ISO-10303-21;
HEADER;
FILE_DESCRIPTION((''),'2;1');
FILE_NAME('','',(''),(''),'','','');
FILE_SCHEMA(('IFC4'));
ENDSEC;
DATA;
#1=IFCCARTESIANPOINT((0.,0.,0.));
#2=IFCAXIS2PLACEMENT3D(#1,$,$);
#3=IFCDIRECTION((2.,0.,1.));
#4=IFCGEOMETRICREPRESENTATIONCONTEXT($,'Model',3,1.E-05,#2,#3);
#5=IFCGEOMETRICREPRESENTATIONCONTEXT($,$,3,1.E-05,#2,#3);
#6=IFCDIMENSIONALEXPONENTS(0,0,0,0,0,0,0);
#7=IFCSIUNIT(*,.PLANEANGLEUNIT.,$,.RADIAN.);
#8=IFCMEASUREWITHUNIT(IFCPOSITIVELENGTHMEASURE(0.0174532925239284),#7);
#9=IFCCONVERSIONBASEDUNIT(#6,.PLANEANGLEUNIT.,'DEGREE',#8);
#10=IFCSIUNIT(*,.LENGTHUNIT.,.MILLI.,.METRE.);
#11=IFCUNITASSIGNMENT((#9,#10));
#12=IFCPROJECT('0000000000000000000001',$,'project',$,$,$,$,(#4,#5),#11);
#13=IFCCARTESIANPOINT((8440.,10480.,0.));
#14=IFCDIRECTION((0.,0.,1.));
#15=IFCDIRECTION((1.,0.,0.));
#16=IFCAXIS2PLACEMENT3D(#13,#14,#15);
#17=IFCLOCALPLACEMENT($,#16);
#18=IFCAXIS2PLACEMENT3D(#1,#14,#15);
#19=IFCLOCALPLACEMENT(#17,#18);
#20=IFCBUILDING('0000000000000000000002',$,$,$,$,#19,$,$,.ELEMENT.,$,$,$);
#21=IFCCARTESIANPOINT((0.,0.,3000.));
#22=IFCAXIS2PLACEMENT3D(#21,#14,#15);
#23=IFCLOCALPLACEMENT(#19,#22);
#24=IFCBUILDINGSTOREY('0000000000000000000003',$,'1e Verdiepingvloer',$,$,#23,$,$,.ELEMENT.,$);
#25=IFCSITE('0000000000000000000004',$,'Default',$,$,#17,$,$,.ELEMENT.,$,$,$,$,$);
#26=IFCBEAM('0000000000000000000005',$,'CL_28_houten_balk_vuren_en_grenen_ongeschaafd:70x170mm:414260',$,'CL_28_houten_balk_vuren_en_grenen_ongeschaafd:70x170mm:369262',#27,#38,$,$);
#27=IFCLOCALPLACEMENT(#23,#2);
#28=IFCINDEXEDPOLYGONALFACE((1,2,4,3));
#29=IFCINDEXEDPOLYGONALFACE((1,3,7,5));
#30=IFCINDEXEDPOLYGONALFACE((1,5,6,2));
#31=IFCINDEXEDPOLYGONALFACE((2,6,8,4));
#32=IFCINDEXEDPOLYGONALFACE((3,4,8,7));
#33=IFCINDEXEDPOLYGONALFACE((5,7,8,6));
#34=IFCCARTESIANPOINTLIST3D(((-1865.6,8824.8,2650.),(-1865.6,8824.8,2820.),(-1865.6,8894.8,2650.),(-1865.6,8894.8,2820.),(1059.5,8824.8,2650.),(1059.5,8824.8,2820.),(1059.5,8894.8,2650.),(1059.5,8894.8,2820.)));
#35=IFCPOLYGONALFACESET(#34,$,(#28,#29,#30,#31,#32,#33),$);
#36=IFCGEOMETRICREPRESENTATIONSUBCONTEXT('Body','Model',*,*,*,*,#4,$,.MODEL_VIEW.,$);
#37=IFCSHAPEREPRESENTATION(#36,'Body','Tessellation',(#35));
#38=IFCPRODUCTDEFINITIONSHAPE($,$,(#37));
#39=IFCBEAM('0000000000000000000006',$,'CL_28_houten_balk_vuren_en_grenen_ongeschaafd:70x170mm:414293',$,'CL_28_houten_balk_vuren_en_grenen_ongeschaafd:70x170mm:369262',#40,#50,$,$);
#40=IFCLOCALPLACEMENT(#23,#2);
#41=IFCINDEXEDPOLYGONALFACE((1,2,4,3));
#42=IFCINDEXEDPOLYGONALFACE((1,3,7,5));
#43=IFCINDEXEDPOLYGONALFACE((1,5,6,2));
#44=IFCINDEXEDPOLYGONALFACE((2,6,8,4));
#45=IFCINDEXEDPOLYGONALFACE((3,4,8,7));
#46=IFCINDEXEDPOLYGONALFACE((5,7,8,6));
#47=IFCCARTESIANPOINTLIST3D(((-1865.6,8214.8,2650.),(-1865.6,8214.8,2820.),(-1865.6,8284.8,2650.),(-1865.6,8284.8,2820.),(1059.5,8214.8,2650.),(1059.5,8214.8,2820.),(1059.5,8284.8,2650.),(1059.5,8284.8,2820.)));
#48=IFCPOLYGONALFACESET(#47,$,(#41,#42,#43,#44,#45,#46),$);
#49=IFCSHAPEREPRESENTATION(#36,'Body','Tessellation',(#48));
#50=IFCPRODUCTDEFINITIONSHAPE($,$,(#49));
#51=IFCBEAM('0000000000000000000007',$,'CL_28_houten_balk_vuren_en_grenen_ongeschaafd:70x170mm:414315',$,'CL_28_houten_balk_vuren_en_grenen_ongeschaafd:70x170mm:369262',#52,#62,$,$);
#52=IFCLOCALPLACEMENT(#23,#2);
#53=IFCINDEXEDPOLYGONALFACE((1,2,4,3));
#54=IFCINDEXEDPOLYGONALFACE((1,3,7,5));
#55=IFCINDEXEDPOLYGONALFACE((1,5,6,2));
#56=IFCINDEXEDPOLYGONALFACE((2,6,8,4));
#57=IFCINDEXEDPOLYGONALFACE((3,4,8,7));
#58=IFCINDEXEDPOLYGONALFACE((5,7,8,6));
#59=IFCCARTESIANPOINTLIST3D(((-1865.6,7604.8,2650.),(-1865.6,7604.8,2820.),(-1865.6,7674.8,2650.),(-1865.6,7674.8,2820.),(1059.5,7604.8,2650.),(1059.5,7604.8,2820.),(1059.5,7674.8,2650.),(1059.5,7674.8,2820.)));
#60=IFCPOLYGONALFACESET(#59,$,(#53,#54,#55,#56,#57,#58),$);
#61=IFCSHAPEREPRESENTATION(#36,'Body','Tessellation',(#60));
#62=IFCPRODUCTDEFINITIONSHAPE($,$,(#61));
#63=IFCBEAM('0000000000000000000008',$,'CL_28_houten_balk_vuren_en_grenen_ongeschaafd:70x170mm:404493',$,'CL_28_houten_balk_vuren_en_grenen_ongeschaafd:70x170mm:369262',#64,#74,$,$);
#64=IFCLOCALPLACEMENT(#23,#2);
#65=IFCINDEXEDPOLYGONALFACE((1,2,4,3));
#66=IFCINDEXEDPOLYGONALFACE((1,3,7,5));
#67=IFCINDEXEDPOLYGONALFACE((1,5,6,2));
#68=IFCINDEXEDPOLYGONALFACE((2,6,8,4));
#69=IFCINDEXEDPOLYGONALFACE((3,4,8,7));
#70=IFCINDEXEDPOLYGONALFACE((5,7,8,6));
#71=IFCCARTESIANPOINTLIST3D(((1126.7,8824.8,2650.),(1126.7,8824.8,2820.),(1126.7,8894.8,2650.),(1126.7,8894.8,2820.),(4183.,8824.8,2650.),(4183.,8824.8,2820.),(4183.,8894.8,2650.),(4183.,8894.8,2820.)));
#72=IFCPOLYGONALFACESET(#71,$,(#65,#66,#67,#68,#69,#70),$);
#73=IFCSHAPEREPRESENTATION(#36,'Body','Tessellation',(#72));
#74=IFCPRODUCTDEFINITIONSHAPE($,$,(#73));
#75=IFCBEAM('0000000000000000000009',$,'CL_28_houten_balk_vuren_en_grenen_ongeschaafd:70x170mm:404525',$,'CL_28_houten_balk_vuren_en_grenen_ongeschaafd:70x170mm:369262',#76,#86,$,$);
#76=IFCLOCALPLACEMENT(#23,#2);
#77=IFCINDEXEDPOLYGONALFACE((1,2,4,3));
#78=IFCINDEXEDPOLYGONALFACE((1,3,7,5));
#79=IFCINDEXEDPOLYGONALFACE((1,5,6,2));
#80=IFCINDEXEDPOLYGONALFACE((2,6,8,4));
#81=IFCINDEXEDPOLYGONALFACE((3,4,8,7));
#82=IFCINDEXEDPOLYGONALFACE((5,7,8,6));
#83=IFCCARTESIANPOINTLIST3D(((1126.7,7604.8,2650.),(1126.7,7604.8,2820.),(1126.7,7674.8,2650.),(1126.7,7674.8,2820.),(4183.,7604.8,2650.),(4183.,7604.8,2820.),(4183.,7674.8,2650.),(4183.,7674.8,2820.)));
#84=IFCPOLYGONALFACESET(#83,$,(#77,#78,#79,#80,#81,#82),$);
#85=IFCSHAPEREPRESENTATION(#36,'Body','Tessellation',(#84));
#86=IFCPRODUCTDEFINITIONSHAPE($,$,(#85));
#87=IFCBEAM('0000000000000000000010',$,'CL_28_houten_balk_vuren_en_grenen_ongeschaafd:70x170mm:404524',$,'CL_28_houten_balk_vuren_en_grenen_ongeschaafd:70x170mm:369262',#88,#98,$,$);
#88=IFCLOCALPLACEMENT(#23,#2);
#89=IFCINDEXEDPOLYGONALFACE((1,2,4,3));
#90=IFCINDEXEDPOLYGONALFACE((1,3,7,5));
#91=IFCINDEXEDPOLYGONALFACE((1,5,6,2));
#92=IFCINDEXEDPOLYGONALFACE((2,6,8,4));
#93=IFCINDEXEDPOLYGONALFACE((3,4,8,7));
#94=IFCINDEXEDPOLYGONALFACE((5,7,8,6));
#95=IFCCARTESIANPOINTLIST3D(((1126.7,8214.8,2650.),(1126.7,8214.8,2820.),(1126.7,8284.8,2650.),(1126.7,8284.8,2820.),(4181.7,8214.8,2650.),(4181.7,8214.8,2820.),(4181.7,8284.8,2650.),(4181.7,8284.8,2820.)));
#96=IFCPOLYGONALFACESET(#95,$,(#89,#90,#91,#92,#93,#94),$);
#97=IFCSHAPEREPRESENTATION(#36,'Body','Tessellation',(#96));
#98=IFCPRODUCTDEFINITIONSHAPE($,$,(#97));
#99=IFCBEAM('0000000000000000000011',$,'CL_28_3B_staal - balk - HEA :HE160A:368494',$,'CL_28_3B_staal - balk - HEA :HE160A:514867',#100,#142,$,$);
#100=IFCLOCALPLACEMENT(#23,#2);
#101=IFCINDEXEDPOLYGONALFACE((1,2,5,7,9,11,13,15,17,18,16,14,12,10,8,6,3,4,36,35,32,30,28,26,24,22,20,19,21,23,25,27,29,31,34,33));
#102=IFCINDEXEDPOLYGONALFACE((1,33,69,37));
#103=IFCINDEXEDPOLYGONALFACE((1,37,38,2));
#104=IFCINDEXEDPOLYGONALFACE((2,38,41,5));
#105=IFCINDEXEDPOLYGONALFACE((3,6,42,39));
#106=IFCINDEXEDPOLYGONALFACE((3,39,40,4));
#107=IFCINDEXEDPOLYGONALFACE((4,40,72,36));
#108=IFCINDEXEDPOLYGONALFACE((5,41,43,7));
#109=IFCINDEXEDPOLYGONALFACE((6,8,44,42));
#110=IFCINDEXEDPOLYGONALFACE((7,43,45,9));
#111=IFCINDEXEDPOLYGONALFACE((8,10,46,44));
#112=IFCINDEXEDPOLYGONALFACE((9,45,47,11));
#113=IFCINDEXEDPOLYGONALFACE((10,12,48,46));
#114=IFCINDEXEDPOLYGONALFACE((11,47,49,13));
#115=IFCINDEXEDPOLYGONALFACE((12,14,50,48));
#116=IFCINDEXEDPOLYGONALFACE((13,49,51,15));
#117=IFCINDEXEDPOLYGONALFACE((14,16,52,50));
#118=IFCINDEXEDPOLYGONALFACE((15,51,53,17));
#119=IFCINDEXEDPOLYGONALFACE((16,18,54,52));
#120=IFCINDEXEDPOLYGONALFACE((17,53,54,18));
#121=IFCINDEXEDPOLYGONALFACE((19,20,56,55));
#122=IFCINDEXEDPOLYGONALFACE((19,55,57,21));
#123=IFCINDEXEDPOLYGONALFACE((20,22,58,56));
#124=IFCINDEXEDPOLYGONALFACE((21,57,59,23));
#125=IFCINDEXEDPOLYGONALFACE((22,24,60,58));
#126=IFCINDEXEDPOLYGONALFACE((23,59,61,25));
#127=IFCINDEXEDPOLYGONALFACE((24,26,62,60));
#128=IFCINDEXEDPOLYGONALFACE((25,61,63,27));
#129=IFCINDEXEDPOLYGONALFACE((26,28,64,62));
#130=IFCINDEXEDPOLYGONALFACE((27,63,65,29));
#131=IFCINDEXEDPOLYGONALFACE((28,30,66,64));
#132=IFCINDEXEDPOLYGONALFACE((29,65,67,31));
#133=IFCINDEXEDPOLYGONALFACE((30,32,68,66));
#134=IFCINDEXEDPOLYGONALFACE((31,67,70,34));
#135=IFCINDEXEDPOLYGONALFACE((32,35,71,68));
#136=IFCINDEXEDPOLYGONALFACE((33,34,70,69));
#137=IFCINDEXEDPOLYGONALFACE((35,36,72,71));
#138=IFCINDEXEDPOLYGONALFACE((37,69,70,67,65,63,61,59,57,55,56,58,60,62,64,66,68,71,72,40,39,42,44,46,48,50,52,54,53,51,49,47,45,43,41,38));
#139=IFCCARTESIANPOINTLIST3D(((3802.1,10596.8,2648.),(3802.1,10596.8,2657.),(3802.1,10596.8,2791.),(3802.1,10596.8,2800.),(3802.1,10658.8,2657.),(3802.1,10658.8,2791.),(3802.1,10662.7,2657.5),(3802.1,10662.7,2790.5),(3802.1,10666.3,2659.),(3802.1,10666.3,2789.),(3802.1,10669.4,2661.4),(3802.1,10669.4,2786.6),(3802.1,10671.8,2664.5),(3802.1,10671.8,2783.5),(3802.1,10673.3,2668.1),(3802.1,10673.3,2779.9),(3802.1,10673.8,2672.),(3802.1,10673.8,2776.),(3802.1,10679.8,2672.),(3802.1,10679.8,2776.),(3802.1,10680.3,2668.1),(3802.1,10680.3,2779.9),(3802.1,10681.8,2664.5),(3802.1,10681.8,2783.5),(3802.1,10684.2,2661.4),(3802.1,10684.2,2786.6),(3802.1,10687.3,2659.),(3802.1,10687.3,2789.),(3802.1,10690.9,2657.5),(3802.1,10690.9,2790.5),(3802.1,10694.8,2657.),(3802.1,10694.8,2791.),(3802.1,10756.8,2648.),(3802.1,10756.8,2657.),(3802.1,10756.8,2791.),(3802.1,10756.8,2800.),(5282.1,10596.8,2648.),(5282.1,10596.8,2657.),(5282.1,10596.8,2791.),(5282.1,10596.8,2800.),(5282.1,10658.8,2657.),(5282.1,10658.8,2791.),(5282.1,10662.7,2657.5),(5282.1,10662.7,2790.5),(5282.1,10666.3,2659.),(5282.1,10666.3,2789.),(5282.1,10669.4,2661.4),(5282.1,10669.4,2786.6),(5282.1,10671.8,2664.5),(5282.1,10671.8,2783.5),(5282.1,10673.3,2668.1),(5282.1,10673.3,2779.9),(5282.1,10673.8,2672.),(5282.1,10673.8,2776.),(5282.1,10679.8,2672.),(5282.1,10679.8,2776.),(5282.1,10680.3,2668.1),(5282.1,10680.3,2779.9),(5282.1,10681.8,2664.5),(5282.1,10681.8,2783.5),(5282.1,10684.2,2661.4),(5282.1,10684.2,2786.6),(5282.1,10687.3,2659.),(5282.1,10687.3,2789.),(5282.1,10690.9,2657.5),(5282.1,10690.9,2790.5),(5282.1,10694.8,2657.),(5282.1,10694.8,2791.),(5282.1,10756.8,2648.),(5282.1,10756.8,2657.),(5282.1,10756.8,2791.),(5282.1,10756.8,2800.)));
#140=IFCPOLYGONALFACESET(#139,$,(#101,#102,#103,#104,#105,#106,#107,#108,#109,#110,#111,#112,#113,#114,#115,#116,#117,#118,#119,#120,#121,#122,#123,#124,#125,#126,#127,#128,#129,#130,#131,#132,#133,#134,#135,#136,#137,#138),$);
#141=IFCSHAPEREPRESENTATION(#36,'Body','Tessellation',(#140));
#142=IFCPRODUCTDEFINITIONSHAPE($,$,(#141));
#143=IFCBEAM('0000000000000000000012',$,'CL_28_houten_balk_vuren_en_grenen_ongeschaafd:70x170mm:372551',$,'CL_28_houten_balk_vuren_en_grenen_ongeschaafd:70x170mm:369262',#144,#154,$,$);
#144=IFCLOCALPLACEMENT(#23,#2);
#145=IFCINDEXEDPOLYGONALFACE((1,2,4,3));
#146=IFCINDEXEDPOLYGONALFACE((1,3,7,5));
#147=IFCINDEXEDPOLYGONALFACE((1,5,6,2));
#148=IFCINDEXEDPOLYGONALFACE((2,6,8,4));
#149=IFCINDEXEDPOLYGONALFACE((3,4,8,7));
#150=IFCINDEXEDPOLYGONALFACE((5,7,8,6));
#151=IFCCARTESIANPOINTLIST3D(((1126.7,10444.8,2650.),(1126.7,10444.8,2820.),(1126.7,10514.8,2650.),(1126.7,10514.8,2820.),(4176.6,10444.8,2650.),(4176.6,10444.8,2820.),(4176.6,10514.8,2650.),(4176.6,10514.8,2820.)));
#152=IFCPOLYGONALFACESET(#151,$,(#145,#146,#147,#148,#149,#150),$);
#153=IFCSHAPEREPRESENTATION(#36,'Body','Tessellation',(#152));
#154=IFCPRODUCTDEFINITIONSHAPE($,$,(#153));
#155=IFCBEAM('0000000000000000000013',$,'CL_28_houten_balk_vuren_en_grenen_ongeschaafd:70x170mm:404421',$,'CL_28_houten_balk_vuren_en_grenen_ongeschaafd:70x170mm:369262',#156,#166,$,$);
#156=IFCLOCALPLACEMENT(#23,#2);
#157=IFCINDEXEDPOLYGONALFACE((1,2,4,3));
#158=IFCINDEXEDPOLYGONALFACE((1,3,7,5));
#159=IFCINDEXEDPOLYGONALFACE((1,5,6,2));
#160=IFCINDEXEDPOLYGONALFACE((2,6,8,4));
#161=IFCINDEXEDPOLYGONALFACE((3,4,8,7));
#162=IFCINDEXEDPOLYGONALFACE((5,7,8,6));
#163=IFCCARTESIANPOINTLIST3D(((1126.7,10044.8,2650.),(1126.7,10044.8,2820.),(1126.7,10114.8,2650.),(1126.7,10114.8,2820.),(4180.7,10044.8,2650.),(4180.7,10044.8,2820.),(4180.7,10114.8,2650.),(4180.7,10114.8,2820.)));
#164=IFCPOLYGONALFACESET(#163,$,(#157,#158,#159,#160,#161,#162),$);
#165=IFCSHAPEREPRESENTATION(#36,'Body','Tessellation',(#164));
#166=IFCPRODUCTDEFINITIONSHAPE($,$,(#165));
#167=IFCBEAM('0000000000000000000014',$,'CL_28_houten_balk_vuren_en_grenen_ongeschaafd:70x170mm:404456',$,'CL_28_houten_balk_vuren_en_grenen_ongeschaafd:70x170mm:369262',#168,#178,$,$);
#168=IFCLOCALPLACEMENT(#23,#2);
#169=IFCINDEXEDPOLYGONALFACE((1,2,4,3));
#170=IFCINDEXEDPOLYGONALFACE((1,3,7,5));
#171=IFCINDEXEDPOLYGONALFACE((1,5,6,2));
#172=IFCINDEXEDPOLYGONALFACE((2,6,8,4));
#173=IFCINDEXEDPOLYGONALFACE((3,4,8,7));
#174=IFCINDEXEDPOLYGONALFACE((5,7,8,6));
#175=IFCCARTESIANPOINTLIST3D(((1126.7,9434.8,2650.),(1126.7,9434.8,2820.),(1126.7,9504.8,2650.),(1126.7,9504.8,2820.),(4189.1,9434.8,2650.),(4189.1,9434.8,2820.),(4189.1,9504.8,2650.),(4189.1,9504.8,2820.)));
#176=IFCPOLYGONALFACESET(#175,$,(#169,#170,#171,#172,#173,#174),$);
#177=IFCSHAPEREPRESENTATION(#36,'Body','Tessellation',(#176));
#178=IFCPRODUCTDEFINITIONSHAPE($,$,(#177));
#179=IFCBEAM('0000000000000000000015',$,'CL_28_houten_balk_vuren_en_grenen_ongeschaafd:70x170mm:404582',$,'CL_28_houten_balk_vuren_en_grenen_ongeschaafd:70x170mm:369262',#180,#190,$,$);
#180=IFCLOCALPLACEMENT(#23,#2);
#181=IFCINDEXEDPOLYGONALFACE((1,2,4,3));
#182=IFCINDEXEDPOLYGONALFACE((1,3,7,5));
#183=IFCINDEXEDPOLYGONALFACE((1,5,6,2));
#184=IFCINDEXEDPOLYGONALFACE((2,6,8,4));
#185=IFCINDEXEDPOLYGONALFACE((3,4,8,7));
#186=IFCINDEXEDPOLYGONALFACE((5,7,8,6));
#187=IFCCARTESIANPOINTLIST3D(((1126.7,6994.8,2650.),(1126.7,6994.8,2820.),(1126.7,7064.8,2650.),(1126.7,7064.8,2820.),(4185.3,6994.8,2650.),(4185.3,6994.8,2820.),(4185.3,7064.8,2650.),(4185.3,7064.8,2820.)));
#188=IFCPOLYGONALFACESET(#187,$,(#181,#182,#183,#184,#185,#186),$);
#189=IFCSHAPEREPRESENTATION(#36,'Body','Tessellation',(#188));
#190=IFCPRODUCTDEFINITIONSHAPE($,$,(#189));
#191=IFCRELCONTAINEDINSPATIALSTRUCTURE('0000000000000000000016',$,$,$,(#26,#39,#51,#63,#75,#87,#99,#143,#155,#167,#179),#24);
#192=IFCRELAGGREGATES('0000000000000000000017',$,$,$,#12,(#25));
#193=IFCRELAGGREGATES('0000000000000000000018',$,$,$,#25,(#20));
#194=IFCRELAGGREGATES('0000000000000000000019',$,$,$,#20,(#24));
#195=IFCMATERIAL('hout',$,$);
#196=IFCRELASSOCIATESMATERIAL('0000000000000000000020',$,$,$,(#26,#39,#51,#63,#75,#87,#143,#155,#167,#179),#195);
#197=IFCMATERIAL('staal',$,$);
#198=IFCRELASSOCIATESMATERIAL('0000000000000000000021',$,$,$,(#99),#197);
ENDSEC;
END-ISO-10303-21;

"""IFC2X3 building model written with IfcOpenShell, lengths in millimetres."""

from ifc_helpers import new_model, entity, si_unit, converted_unit, direction, frame, frame_2d, origin, origin_with_axes, place, context, subcontext, project, spatial, rectangle, i_section, extrude, source, transform, mapped, material, element, save


model = new_model("IFC2X3")

# Units and contexts
model_context = context("Model", 3, precision=1e-05, world=origin(), true_north=direction((2.0, 0.0, 1.0)))
context_of_model = context(None, 3, precision=1e-05, world=origin(), true_north=direction((2.0, 0.0, 1.0)))
body_context = subcontext(model_context, "Body", "Model", "MODEL_VIEW")
ifc_project = project(units=[converted_unit("PLANEANGLEUNIT", "DEGREE", entity("IfcPositiveLengthMeasure", 0.0174532925239284), si_unit("PLANEANGLEUNIT", "RADIAN"), dimensions=[0, 0, 0, 0, 0, 0, 0]), si_unit("LENGTHUNIT", "METRE", prefix="MILLI")], contexts=[model_context, context_of_model])

# Site, building, storey
site_placement = place(None, frame((8440.0, 10480.0, 0.0), z_axis=(0.0, 0.0, 1.0), x_axis=(1.0, 0.0, 0.0)))
site = spatial("IfcSite", under=ifc_project, at=site_placement, Name="Default", CompositionType="ELEMENT")
building_placement = place(site_placement, origin_with_axes())
building = spatial("IfcBuilding", under=site, at=building_placement, CompositionType="ELEMENT")
storey_placement = place(building_placement, frame((0.0, 0.0, 3000.0), z_axis=(0.0, 0.0, 1.0), x_axis=(1.0, 0.0, 0.0)))
storey = spatial("IfcBuildingStorey", under=building, at=storey_placement, Name="1e Verdiepingvloer", CompositionType="ELEMENT")

# Beams
ifc_material_1 = material(Name="hout")
shared_shape_1 = source(origin(), body_context, "Body", "SweptSolid", [
    extrude(rectangle(XDim=170.0, YDim=70.0, at=frame_2d((0.0, 0.0), x_axis=(1.0, 0.0))), frame((263.4, 0.0, -85.0), z_axis=(1.0, 0.0, 0.0), x_axis=(0.0, 0.0, -1.0)), (0.0, 0.0, 1.0), 2925.0),
])
for number, where, z_axis, x_axis, name in (
    (1, (-2128.9, 8859.8, 2820.0), (0.0, 0.0, 1.0), (1.0, 0.0, 0.0), "CL_28_houten_balk_vuren_en_grenen_ongeschaafd:70x170mm:414260"),
    (2, (-2128.9, 8249.8, 2820.0), (0.0, 0.0, 1.0), (1.0, 0.0, 0.0), "CL_28_houten_balk_vuren_en_grenen_ongeschaafd:70x170mm:414293"),
    (3, (-2128.9, 7639.8, 2820.0), (0.0, 0.0, 1.0), (1.0, 0.0, 0.0), "CL_28_houten_balk_vuren_en_grenen_ongeschaafd:70x170mm:414315"),
):
    element("IfcBeam", number, at=place(storey_placement, frame(where, z_axis=z_axis, x_axis=x_axis)), inside=storey, material=ifc_material_1, Name=name, ObjectType="CL_28_houten_balk_vuren_en_grenen_ongeschaafd:70x170mm:369262", context=body_context, shape_type="MappedRepresentation", body=[
        mapped(shared_shape_1, transform((0.0, 0.0, 0.0))),
    ])
shared_shape_2 = source(origin(), body_context, "Body", "SweptSolid", [
    extrude(rectangle(XDim=170.0, YDim=70.0, at=frame_2d((0.0, 0.0), x_axis=(1.0, 0.0))), frame((155.6, 0.0, -85.0), z_axis=(1.0, 0.0, 0.0), x_axis=(0.0, 0.0, -1.0)), (0.0, 0.0, 1.0), 3056.3),
])
for number, where, z_axis, x_axis, name in (
    (4, (971.1, 8859.8, 2820.0), (0.0, 0.0, 1.0), (1.0, 0.0, 0.0), "CL_28_houten_balk_vuren_en_grenen_ongeschaafd:70x170mm:404493"),
    (5, (971.1, 7639.8, 2820.0), (0.0, 0.0, 1.0), (1.0, 0.0, 0.0), "CL_28_houten_balk_vuren_en_grenen_ongeschaafd:70x170mm:404525"),
):
    element("IfcBeam", number, at=place(storey_placement, frame(where, z_axis=z_axis, x_axis=x_axis)), inside=storey, material=ifc_material_1, Name=name, ObjectType="CL_28_houten_balk_vuren_en_grenen_ongeschaafd:70x170mm:369262", context=body_context, shape_type="MappedRepresentation", body=[
        mapped(shared_shape_2, transform((0.0, 0.0, 0.0))),
    ])
shared_shape_3 = source(origin(), body_context, "Body", "SweptSolid", [
    extrude(rectangle(XDim=170.0, YDim=70.0, at=frame_2d((0.0, 0.0), x_axis=(1.0, 0.0))), frame((155.6, 0.0, -85.0), z_axis=(1.0, 0.0, 0.0), x_axis=(0.0, 0.0, -1.0)), (0.0, 0.0, 1.0), 3055.0),
])
beam_1_placement = place(storey_placement, frame((971.1, 8249.8, 2820.0), z_axis=(0.0, 0.0, 1.0), x_axis=(1.0, 0.0, 0.0)))
element("IfcBeam", 6, at=beam_1_placement, inside=storey, material=ifc_material_1, Name="CL_28_houten_balk_vuren_en_grenen_ongeschaafd:70x170mm:404524", ObjectType="CL_28_houten_balk_vuren_en_grenen_ongeschaafd:70x170mm:369262", context=body_context, shape_type="MappedRepresentation", body=[
    mapped(shared_shape_3, transform((0.0, 0.0, 0.0))),
])
ifc_material_2 = material(Name="staal")
beam_2_placement = place(storey_placement, frame((3802.1, 10676.8, 2800.0), z_axis=(0.0, 0.0, 1.0), x_axis=(1.0, 0.0, 0.0)))
element("IfcBeam", 7, at=beam_2_placement, inside=storey, material=ifc_material_2, Name="CL_28_3B_staal - balk - HEA :HE160A:368494", ObjectType="CL_28_3B_staal - balk - HEA :HE160A:514867", context=body_context, shape_type="SweptSolid", body=[
    extrude(i_section(OverallWidth=160.0, OverallDepth=152.0, WebThickness=6.0, FlangeThickness=9.0, FilletRadius=15.0, at=frame_2d((0.0, 0.0), x_axis=(0.0, 1.0))), frame((0.0, 0.0, -76.0), z_axis=(1.0, 0.0, 0.0), x_axis=(0.0, 0.0, -1.0)), (0.0, 0.0, 1.0), 1480.0),
])
beam_3_placement = place(storey_placement, frame((971.1, 10479.8, 2820.0), z_axis=(0.0, 0.0, 1.0), x_axis=(1.0, 0.0, 0.0)))
element("IfcBeam", 8, at=beam_3_placement, inside=storey, material=ifc_material_1, Name="CL_28_houten_balk_vuren_en_grenen_ongeschaafd:70x170mm:372551", ObjectType="CL_28_houten_balk_vuren_en_grenen_ongeschaafd:70x170mm:369262", context=body_context, shape_type="SweptSolid", body=[
    extrude(rectangle(XDim=170.0, YDim=70.0, at=frame_2d((0.0, 0.0), x_axis=(1.0, 0.0))), frame((155.6, 0.0, -85.0), z_axis=(1.0, 0.0, 0.0), x_axis=(0.0, 0.0, -1.0)), (0.0, 0.0, 1.0), 3049.9),
])
beam_4_placement = place(storey_placement, frame((971.1, 10079.8, 2820.0), z_axis=(0.0, 0.0, 1.0), x_axis=(1.0, 0.0, 0.0)))
element("IfcBeam", 9, at=beam_4_placement, inside=storey, material=ifc_material_1, Name="CL_28_houten_balk_vuren_en_grenen_ongeschaafd:70x170mm:404421", ObjectType="CL_28_houten_balk_vuren_en_grenen_ongeschaafd:70x170mm:369262", context=body_context, shape_type="SweptSolid", body=[
    extrude(rectangle(XDim=170.0, YDim=70.0, at=frame_2d((0.0, 0.0), x_axis=(1.0, 0.0))), frame((155.6, 0.0, -85.0), z_axis=(1.0, 0.0, 0.0), x_axis=(0.0, 0.0, -1.0)), (0.0, 0.0, 1.0), 3054.1),
])
beam_5_placement = place(storey_placement, frame((971.1, 9469.8, 2820.0), z_axis=(0.0, 0.0, 1.0), x_axis=(1.0, 0.0, 0.0)))
element("IfcBeam", 10, at=beam_5_placement, inside=storey, material=ifc_material_1, Name="CL_28_houten_balk_vuren_en_grenen_ongeschaafd:70x170mm:404456", ObjectType="CL_28_houten_balk_vuren_en_grenen_ongeschaafd:70x170mm:369262", context=body_context, shape_type="SweptSolid", body=[
    extrude(rectangle(XDim=170.0, YDim=70.0, at=frame_2d((0.0, 0.0), x_axis=(1.0, 0.0))), frame((155.6, 0.0, -85.0), z_axis=(1.0, 0.0, 0.0), x_axis=(0.0, 0.0, -1.0)), (0.0, 0.0, 1.0), 3062.4),
])
beam_6_placement = place(storey_placement, frame((971.1, 7029.8, 2820.0), z_axis=(0.0, 0.0, 1.0), x_axis=(1.0, 0.0, 0.0)))
element("IfcBeam", 11, at=beam_6_placement, inside=storey, material=ifc_material_1, Name="CL_28_houten_balk_vuren_en_grenen_ongeschaafd:70x170mm:404582", ObjectType="CL_28_houten_balk_vuren_en_grenen_ongeschaafd:70x170mm:369262", context=body_context, shape_type="SweptSolid", body=[
    extrude(rectangle(XDim=170.0, YDim=70.0, at=frame_2d((0.0, 0.0), x_axis=(1.0, 0.0))), frame((155.6, 0.0, -85.0), z_axis=(1.0, 0.0, 0.0), x_axis=(0.0, 0.0, -1.0)), (0.0, 0.0, 1.0), 3058.6),
])

save(model, "model.ifc")
